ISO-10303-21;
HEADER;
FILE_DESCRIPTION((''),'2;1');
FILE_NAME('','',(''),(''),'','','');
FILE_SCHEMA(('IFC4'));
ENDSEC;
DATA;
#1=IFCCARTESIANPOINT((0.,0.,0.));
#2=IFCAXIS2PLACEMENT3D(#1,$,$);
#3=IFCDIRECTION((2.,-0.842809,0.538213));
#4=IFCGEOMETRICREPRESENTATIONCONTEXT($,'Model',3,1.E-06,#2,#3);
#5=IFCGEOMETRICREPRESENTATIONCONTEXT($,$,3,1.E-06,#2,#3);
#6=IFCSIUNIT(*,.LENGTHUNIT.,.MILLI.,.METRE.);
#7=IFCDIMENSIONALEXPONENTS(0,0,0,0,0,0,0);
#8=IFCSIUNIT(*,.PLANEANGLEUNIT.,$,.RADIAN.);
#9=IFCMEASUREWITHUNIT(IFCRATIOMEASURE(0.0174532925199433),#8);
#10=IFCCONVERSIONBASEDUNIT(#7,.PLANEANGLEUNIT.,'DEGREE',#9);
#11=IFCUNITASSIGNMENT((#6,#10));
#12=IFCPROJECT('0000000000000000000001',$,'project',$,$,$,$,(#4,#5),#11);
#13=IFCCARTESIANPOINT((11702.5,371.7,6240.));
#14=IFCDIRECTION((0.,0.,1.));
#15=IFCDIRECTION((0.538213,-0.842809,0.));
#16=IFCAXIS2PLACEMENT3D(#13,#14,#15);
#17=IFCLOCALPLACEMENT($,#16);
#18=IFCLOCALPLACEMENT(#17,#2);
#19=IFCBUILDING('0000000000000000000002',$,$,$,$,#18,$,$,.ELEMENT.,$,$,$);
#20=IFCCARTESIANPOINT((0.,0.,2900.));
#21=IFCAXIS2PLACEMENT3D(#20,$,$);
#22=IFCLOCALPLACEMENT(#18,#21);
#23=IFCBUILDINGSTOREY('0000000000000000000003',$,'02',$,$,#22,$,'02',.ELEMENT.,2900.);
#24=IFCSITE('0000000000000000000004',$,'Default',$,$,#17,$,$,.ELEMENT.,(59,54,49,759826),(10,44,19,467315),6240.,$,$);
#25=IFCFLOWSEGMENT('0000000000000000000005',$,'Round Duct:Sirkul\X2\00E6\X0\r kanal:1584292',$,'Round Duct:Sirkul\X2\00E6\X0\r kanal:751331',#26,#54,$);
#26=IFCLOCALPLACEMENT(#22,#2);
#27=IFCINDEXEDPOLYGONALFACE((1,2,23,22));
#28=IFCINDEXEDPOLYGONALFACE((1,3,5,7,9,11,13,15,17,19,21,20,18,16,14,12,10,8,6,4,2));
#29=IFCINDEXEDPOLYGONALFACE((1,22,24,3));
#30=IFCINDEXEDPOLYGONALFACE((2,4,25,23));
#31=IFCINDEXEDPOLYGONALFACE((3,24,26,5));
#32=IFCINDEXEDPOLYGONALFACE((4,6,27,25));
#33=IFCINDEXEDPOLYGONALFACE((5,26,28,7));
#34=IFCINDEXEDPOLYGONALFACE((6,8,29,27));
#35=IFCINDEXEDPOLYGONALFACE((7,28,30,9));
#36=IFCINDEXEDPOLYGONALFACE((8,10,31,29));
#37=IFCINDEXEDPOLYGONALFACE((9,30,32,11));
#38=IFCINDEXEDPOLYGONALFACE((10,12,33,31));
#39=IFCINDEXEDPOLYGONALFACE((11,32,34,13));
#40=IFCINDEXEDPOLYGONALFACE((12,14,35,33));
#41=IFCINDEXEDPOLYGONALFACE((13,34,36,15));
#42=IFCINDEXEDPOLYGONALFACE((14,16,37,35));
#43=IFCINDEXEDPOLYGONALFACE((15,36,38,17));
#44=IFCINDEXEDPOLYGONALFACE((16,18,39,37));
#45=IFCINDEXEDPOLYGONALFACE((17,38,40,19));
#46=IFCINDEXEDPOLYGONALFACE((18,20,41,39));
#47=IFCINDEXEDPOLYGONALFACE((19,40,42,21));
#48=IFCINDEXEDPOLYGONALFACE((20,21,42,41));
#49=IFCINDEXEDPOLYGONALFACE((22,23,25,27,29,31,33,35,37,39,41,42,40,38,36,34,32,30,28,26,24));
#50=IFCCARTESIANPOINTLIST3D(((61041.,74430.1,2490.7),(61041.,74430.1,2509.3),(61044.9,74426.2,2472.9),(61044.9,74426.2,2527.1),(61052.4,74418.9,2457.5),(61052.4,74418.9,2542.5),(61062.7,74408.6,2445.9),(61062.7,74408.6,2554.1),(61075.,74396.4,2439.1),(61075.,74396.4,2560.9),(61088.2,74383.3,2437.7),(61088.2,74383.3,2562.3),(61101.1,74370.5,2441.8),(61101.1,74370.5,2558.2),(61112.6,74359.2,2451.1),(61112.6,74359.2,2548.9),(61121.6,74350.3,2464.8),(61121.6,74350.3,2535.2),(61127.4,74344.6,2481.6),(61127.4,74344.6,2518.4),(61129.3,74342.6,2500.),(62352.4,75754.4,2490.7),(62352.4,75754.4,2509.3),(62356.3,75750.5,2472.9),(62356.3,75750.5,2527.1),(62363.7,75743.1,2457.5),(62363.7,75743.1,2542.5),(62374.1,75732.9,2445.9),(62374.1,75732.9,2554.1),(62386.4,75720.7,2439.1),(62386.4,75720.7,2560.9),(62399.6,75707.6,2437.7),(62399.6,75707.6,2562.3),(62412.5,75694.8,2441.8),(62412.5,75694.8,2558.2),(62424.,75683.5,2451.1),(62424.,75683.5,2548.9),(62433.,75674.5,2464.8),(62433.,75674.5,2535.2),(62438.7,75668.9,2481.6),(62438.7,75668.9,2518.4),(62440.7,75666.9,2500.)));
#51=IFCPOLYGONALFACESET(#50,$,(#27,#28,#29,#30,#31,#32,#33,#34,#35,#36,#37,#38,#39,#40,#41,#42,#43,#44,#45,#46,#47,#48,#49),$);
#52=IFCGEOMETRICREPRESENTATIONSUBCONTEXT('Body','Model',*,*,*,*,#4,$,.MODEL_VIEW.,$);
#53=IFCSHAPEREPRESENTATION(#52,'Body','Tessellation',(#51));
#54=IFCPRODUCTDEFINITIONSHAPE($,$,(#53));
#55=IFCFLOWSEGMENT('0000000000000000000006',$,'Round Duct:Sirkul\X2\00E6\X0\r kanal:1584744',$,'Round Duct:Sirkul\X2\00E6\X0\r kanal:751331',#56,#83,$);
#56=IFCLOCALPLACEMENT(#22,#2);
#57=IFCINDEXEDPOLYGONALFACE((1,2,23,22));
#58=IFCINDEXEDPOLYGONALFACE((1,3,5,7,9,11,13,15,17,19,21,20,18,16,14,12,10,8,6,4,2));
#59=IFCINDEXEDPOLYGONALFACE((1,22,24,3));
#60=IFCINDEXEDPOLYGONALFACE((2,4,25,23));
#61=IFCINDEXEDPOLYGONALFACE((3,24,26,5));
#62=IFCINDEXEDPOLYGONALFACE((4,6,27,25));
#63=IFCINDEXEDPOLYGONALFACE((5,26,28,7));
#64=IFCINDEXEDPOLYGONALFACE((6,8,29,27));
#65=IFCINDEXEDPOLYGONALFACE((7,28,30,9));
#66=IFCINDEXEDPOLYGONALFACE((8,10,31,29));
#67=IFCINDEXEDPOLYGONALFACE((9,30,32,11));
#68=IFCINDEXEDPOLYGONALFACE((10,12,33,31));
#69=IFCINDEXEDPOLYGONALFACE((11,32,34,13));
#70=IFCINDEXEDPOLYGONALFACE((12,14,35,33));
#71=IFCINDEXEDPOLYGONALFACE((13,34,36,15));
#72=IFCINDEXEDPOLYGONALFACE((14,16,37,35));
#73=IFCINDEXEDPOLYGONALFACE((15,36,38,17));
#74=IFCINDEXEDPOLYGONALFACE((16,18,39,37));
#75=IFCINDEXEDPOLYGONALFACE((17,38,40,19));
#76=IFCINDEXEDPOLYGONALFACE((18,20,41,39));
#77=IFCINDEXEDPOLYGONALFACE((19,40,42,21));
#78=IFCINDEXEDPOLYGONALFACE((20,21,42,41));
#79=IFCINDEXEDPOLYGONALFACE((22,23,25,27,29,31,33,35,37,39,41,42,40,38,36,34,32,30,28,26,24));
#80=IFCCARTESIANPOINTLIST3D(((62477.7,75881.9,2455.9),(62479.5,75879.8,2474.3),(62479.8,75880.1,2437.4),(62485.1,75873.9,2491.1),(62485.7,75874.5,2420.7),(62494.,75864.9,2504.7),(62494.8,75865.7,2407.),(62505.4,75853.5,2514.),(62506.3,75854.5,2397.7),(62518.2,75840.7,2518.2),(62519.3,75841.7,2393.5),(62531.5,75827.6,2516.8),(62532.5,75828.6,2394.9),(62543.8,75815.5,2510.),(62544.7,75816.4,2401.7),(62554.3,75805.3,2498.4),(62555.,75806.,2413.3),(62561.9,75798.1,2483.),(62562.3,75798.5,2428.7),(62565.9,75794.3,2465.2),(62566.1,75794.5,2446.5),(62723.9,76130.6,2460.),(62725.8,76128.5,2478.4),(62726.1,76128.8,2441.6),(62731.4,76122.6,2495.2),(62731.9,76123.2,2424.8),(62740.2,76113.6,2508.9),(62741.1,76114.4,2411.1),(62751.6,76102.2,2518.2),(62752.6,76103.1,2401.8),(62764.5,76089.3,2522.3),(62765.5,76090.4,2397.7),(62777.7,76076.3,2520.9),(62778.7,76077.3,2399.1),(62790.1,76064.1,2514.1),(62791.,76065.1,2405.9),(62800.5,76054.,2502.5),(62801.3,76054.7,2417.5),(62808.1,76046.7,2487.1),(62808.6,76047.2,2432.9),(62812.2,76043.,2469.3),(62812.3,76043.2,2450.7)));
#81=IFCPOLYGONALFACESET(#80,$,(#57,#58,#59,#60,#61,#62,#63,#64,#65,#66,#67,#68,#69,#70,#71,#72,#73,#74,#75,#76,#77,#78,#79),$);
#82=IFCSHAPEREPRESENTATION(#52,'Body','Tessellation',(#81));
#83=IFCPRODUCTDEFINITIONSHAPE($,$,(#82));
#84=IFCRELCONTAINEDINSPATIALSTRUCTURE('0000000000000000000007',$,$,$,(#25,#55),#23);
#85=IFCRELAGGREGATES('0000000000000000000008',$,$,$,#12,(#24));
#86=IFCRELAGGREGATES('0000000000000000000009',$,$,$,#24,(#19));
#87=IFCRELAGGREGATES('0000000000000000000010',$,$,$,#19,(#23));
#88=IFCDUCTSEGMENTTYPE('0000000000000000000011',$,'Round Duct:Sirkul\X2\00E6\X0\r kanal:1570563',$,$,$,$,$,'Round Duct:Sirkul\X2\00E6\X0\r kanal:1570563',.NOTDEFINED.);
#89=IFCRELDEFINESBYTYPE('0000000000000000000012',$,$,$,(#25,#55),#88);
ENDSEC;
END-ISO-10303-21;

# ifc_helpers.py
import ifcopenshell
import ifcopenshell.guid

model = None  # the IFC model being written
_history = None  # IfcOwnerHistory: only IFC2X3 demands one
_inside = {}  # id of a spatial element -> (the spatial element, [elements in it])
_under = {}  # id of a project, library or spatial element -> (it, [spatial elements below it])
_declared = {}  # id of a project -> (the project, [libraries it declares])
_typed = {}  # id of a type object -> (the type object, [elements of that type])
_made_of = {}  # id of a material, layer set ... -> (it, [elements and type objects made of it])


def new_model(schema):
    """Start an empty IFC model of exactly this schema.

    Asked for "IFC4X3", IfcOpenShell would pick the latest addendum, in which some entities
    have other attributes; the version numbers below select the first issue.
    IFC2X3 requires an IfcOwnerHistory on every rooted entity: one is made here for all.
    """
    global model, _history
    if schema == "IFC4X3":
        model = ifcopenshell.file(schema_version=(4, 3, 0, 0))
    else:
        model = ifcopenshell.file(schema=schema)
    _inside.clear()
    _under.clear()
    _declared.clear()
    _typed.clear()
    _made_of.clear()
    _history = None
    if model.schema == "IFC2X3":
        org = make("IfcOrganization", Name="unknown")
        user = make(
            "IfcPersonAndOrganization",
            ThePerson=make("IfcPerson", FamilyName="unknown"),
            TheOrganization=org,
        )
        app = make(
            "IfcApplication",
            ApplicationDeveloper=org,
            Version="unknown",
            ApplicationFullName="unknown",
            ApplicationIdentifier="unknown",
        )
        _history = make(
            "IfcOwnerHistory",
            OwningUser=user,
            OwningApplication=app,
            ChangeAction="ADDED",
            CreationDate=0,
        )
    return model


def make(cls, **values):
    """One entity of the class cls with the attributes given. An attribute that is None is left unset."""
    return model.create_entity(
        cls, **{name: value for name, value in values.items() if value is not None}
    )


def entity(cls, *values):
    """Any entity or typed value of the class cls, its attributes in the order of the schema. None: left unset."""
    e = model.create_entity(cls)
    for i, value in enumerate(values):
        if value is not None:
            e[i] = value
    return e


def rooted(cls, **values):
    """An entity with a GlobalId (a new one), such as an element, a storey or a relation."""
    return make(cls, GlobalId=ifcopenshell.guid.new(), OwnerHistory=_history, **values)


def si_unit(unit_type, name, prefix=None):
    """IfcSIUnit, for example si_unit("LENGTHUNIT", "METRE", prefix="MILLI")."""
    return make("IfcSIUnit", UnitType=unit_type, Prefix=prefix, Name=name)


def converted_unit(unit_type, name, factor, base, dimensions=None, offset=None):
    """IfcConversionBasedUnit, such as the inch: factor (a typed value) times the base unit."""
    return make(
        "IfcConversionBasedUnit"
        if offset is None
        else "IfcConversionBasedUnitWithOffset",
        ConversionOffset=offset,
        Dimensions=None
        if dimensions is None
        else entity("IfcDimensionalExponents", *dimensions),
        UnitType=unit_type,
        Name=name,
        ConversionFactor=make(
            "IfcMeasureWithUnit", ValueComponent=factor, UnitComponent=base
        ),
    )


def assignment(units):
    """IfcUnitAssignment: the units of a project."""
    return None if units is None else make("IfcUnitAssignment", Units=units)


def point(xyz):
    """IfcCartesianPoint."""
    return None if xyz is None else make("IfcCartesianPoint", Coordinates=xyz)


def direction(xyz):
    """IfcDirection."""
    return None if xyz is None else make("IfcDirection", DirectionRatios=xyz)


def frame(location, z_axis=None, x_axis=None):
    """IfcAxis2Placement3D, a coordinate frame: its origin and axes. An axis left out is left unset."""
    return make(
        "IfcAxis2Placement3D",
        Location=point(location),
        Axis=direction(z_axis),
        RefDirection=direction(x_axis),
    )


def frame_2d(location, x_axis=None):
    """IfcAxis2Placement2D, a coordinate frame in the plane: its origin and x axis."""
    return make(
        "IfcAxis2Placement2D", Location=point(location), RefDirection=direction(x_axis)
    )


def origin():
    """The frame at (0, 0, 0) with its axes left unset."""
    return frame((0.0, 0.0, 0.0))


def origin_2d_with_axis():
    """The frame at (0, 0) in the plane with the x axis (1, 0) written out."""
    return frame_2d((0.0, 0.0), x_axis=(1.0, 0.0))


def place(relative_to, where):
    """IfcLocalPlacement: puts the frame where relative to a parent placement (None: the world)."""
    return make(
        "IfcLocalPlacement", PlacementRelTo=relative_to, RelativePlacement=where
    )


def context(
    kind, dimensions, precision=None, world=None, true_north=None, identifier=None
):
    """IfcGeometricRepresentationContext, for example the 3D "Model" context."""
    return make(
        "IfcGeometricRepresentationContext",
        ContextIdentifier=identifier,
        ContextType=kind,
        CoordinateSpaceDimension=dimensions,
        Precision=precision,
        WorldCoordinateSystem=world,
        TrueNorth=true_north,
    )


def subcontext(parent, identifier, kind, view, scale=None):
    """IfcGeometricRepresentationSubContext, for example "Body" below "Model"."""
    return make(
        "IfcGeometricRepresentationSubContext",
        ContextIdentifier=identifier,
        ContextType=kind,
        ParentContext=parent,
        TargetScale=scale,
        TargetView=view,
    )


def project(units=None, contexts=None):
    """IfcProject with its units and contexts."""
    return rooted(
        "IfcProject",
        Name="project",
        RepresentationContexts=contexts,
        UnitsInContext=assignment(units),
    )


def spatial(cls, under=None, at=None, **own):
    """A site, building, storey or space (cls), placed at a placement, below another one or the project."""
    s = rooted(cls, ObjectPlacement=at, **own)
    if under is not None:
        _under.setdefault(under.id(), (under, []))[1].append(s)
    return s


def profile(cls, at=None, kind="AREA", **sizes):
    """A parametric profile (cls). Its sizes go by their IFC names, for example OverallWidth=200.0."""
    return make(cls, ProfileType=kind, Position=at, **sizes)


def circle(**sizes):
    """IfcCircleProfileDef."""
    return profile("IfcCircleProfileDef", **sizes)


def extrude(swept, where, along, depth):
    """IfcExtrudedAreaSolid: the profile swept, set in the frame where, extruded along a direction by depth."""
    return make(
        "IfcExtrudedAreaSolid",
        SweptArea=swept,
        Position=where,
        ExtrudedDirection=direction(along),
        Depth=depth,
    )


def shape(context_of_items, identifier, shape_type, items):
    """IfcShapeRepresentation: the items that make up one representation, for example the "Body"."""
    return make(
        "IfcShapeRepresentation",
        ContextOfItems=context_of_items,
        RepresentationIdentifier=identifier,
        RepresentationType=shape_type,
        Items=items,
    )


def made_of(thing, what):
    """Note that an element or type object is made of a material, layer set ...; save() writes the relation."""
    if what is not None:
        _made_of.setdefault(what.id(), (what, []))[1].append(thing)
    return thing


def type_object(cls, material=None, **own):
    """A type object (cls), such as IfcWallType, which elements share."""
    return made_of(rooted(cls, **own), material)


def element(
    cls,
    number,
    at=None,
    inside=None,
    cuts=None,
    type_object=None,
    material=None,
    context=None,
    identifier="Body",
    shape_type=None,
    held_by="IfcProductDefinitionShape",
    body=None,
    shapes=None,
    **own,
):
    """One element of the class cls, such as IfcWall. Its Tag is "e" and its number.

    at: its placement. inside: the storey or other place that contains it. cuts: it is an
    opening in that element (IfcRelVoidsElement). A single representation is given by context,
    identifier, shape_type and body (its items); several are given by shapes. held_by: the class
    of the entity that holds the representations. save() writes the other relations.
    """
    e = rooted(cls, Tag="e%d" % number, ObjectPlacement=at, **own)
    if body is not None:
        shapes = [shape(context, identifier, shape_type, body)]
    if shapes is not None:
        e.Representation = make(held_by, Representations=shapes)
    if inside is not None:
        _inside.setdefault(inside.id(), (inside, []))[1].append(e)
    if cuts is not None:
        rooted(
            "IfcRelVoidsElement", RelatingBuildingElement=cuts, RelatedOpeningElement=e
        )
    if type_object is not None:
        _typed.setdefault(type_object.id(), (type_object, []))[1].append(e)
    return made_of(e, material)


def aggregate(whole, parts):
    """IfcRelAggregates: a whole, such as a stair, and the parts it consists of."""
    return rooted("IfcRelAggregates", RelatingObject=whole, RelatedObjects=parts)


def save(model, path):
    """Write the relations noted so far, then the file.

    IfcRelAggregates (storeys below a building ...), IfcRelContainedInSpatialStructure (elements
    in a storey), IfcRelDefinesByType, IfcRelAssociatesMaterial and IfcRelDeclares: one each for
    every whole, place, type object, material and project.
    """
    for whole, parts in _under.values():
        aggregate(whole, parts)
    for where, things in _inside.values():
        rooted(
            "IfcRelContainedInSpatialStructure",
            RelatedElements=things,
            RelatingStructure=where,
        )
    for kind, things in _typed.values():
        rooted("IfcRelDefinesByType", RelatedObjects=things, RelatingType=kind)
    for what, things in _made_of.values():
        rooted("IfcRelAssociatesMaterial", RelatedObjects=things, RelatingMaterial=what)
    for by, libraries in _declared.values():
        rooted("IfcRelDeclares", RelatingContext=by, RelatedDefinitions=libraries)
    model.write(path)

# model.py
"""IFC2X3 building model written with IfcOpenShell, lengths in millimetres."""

from ifc_helpers import new_model, entity, si_unit, converted_unit, direction, frame, origin, origin_2d_with_axis, place, context, subcontext, project, spatial, circle, extrude, type_object, element, save


model = new_model("IFC2X3")

# Units and contexts
model_context = context("Model", 3, precision=1e-06, world=origin(), true_north=direction((2.0, -0.842809, 0.538213)))
context_of_model = context(None, 3, precision=1e-06, world=origin(), true_north=direction((2.0, -0.842809, 0.538213)))
body_context = subcontext(model_context, "Body", "Model", "MODEL_VIEW")
ifc_project = project(units=[si_unit("LENGTHUNIT", "METRE", prefix="MILLI"), converted_unit("PLANEANGLEUNIT", "DEGREE", entity("IfcRatioMeasure", 0.0174532925199433), si_unit("PLANEANGLEUNIT", "RADIAN"), dimensions=[0, 0, 0, 0, 0, 0, 0])], contexts=[model_context, context_of_model])

# Site, building, storey
site_placement = place(None, frame((11702.5, 371.7, 6240.0), z_axis=(0.0, 0.0, 1.0), x_axis=(0.538213, -0.842809, 0.0)))
site = spatial("IfcSite", under=ifc_project, at=site_placement, Name="Default", CompositionType="ELEMENT", RefLatitude=(59, 54, 49, 759826), RefLongitude=(10, 44, 19, 467315), RefElevation=6240.0)
building_placement = place(site_placement, origin())
building = spatial("IfcBuilding", under=site, at=building_placement, CompositionType="ELEMENT")
storey_placement = place(building_placement, frame((0.0, 0.0, 2900.0)))
storey = spatial("IfcBuildingStorey", under=building, at=storey_placement, Name="02", LongName="02", CompositionType="ELEMENT", Elevation=2900.0)

# Flow segments
duct_segment_type = type_object("IfcDuctSegmentType", Name="Round Duct:Sirkulær kanal:1570563", ElementType="Round Duct:Sirkulær kanal:1570563", PredefinedType="NOTDEFINED")
flow_segment_1_placement = place(storey_placement, origin())
element("IfcFlowSegment", 1, at=flow_segment_1_placement, inside=storey, type_object=duct_segment_type, Name="Round Duct:Sirkulær kanal:1584292", ObjectType="Round Duct:Sirkulær kanal:751331", context=body_context, shape_type="SweptSolid", body=[
    extrude(circle(Radius=62.5, at=origin_2d_with_axis()), frame((61084.9, 74386.6, 2500.0), z_axis=(0.703641, 0.710556, 0.0), x_axis=(0.710556, -0.703641, 0.0)), (0.0, 0.0, 1.0), 1863.7),
])
flow_segment_2_placement = place(storey_placement, origin())
element("IfcFlowSegment", 2, at=flow_segment_2_placement, inside=storey, type_object=duct_segment_type, Name="Round Duct:Sirkulær kanal:1584744", ObjectType="Round Duct:Sirkulær kanal:751331", context=body_context, shape_type="SweptSolid", body=[
    extrude(circle(Radius=62.5, at=origin_2d_with_axis()), frame((62522.1, 75837.9, 2455.9), z_axis=(0.703591, 0.710507, 0.011839), x_axis=(-0.710557, 0.70364, 0.0)), (0.0, 0.0, 1.0), 350.0),
])

save(model, "model.ifc")
